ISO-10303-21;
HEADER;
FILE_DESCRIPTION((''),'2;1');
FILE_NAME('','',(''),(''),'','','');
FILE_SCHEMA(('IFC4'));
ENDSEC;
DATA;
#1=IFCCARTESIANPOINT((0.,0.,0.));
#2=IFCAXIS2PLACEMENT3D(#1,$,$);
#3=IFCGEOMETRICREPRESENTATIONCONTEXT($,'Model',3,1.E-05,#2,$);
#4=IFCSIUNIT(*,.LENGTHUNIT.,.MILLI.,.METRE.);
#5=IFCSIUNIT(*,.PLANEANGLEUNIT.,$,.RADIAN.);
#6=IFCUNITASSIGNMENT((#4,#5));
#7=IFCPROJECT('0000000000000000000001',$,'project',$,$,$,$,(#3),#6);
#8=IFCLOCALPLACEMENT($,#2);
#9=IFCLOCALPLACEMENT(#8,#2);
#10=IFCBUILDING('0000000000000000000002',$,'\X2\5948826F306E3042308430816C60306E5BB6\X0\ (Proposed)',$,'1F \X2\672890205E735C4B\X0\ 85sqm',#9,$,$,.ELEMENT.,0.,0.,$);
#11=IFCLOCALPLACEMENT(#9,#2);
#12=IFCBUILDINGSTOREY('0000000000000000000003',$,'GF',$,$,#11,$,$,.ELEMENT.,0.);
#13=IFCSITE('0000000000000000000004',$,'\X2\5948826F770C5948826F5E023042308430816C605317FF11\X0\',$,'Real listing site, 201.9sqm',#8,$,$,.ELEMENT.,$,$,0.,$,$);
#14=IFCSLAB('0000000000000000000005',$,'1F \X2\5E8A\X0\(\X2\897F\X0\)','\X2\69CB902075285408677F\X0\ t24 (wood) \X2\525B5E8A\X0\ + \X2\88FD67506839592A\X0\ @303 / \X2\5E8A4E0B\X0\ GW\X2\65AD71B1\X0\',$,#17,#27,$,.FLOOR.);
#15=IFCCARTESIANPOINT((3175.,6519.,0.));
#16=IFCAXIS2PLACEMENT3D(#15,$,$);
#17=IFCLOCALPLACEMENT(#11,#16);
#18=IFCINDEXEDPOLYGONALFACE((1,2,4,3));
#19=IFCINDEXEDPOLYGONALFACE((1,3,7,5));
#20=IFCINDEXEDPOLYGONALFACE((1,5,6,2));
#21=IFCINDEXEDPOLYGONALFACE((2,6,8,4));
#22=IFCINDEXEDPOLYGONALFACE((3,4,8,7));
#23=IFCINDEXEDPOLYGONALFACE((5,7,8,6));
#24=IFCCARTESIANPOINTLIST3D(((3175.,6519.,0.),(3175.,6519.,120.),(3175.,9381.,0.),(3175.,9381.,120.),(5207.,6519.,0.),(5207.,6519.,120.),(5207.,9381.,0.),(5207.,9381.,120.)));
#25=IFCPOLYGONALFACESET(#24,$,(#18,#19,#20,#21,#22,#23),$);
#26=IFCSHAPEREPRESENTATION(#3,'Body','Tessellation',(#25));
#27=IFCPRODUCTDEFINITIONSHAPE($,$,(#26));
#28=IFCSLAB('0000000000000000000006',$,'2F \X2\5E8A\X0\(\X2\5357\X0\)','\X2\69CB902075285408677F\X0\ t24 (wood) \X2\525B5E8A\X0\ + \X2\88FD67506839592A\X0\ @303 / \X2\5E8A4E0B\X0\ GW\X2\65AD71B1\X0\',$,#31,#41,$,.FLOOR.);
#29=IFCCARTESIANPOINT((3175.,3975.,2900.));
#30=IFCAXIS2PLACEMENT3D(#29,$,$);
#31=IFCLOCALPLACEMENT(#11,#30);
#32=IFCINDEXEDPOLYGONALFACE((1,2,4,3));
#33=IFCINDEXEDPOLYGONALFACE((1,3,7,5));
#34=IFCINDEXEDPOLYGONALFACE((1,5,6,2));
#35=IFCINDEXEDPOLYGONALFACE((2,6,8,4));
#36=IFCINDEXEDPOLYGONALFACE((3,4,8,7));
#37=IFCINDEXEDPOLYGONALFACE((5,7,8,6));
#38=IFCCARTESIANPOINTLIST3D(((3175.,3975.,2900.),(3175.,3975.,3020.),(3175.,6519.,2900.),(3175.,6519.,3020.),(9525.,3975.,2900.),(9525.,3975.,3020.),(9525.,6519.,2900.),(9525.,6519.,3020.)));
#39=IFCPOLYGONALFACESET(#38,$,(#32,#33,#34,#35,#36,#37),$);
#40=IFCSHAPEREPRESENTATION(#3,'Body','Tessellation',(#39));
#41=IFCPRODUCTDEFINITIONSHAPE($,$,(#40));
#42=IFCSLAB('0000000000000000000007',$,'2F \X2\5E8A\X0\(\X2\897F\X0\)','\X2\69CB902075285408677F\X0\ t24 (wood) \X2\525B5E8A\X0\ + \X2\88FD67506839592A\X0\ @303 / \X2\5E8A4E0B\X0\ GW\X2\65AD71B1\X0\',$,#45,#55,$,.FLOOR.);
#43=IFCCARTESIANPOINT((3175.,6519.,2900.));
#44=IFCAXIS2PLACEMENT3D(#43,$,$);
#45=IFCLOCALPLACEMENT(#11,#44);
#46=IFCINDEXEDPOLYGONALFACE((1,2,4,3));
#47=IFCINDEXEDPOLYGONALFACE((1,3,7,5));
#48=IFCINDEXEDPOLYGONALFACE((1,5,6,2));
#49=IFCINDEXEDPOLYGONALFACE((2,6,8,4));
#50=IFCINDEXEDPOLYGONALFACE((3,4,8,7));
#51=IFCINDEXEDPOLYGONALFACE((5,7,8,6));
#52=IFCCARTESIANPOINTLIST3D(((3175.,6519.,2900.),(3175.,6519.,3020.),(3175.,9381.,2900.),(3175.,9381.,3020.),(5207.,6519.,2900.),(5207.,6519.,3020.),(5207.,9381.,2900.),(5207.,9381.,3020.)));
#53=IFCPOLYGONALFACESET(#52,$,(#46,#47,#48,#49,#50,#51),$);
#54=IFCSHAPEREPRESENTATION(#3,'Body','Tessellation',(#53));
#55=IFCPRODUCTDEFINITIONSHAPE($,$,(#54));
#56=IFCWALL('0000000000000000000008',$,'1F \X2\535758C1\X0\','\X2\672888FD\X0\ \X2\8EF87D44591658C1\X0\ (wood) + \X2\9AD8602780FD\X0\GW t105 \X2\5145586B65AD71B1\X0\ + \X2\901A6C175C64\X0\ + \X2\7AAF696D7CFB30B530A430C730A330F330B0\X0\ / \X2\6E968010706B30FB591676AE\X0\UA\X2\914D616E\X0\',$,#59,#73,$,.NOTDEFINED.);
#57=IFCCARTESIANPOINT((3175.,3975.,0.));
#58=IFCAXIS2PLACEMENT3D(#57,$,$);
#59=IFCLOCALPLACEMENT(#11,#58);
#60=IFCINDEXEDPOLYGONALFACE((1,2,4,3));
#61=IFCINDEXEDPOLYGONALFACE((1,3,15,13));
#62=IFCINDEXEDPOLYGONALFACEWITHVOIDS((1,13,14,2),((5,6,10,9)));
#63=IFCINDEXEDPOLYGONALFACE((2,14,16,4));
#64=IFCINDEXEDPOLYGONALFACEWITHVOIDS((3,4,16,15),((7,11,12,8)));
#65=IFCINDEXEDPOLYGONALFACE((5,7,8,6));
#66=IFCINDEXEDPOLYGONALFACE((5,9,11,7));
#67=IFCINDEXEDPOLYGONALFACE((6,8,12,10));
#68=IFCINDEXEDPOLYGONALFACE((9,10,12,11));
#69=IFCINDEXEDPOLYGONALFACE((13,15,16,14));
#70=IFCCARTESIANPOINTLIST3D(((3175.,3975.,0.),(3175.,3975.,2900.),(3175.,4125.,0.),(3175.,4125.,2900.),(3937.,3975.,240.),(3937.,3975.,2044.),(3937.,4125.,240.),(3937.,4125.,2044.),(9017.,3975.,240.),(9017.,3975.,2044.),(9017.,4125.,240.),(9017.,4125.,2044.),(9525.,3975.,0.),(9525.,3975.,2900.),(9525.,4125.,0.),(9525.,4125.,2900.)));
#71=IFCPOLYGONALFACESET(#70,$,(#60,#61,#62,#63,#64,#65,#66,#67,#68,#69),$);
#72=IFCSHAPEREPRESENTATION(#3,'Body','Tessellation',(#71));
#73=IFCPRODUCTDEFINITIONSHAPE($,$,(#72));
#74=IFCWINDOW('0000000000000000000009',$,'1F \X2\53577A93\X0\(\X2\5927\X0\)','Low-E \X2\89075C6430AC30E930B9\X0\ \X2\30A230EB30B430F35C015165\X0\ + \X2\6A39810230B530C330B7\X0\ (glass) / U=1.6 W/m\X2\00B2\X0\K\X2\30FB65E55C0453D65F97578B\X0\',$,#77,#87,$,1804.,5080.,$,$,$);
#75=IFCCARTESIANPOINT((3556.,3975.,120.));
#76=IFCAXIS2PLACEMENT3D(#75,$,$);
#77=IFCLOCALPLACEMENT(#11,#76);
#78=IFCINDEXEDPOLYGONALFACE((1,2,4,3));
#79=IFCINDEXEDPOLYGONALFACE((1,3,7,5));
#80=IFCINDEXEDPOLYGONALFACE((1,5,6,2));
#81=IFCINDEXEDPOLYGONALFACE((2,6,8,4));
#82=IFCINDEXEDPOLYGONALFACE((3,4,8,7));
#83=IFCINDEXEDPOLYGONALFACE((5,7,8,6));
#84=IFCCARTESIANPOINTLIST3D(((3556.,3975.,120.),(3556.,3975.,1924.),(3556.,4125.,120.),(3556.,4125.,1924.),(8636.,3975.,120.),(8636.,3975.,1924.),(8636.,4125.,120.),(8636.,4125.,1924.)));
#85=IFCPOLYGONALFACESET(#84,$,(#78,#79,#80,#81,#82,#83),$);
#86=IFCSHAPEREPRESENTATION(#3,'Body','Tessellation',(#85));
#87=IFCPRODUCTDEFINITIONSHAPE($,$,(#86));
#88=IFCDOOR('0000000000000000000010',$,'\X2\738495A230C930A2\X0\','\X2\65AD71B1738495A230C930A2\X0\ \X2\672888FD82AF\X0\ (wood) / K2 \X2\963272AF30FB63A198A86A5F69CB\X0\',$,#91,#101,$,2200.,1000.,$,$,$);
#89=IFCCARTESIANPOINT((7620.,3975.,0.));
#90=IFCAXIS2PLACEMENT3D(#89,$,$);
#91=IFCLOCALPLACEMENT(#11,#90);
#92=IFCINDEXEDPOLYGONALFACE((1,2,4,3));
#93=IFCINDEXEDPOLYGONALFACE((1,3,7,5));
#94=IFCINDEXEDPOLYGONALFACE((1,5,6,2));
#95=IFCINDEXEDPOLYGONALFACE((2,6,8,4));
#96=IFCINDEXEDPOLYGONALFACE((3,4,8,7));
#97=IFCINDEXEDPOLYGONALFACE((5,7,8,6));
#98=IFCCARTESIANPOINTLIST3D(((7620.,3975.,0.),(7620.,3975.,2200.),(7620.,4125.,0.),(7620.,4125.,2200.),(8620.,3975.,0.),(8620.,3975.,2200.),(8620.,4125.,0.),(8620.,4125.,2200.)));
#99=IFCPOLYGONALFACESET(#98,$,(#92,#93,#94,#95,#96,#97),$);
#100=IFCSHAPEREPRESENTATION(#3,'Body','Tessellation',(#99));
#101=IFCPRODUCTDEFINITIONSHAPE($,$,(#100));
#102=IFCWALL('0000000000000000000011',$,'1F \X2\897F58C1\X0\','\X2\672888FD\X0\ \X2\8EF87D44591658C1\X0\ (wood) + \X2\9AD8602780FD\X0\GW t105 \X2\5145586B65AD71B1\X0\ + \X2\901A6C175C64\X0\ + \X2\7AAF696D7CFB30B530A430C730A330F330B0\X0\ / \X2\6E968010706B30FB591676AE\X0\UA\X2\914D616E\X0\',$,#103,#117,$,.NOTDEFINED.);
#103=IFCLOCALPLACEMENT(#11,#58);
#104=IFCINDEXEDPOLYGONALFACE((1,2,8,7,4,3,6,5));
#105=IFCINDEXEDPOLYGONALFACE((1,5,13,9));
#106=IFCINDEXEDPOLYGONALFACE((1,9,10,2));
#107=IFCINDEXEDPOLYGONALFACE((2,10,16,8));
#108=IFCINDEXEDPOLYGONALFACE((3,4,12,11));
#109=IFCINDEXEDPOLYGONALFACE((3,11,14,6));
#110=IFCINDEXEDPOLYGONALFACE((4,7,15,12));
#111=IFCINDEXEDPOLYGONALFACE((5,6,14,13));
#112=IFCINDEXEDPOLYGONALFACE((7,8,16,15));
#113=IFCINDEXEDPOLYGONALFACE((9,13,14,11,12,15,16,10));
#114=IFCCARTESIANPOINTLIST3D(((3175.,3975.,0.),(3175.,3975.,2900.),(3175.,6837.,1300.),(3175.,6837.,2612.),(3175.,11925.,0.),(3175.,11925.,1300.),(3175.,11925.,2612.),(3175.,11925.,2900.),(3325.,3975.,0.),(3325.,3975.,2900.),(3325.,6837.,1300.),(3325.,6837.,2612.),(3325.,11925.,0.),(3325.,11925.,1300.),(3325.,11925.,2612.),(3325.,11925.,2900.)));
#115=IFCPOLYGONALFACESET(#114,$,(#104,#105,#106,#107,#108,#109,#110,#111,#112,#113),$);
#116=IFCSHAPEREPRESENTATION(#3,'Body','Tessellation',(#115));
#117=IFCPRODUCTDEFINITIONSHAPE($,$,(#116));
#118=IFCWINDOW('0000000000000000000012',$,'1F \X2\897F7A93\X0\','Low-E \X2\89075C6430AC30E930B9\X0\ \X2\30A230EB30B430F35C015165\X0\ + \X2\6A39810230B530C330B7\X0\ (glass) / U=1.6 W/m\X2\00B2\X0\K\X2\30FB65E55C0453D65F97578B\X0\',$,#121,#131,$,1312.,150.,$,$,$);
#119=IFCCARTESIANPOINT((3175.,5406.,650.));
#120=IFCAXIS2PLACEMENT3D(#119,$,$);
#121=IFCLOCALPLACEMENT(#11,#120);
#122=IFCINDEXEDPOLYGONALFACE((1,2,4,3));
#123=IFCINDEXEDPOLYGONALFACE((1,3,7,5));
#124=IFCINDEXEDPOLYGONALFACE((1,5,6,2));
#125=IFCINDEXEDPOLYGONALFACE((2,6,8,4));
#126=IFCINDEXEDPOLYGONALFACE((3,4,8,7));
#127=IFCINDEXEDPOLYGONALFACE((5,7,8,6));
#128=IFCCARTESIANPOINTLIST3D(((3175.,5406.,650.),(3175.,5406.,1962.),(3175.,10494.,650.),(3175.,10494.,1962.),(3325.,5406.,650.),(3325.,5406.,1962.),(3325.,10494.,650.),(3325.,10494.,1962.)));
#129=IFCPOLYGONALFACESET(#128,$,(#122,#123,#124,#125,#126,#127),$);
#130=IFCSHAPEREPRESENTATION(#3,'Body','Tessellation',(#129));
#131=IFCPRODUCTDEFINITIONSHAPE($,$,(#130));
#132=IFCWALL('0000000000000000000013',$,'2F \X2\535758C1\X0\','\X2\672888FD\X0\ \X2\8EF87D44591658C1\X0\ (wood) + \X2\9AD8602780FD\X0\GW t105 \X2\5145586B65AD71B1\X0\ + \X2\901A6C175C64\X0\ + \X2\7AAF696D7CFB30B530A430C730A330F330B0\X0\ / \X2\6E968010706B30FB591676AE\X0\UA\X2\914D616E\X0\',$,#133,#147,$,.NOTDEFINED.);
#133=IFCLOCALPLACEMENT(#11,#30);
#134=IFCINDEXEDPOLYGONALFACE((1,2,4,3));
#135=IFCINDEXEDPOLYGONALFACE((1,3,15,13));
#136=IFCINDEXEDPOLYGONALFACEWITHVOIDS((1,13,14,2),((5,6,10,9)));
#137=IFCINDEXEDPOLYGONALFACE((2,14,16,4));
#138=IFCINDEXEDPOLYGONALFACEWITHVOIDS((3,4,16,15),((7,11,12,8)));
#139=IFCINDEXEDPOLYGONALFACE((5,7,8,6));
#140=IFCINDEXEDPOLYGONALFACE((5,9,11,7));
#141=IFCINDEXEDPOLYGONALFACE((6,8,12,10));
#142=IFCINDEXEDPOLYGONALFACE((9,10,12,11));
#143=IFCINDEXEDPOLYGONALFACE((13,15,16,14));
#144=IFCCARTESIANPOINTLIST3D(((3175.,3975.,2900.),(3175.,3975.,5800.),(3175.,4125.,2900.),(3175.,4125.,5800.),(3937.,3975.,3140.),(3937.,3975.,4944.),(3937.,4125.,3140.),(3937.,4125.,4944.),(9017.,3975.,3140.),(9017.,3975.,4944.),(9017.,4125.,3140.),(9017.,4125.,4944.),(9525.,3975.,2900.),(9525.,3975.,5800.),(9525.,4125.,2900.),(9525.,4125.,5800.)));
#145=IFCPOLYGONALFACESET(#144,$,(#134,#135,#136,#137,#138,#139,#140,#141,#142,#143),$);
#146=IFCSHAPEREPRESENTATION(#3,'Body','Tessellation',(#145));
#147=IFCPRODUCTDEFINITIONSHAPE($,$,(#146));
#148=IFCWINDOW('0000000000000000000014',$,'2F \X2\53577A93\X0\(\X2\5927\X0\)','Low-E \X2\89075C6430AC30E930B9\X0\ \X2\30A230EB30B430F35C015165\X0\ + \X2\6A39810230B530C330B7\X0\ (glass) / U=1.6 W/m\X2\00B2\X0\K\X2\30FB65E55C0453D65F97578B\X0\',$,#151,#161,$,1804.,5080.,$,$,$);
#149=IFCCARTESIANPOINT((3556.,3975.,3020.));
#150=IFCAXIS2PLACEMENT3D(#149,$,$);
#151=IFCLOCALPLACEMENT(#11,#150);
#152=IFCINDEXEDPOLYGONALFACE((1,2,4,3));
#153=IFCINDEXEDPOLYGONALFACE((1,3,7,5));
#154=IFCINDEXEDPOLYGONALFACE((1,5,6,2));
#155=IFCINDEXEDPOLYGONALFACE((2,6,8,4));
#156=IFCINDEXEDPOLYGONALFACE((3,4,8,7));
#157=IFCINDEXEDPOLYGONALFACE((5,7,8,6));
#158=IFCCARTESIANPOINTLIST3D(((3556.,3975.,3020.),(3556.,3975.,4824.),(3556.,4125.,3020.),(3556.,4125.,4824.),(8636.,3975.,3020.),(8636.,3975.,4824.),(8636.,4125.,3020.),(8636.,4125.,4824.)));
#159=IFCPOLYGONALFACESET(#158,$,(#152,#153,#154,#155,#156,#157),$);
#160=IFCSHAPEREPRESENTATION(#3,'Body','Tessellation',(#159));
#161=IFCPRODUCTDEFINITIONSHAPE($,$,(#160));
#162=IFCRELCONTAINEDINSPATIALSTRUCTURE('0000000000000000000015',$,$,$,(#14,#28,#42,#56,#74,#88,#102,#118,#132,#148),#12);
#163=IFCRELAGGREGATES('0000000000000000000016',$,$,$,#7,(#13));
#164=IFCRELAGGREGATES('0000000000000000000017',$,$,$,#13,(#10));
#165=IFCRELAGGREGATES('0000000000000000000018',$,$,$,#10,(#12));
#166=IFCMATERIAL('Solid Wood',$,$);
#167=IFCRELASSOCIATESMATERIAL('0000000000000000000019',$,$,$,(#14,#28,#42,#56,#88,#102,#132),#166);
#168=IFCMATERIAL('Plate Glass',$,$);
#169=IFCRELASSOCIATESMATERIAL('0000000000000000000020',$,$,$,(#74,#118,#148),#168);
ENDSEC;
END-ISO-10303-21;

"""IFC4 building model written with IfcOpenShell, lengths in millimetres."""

from ifc_helpers import new_model, si_unit, frame, frame_2d, origin, place, context, project, spatial, rectangle, extrude, material, element, fill, save


model = new_model("IFC4")

# Units and contexts
model_context = context("Model", 3, precision=1e-05, world=origin())
ifc_project = project(units=[si_unit("LENGTHUNIT", "METRE", prefix="MILLI"), si_unit("PLANEANGLEUNIT", "RADIAN")], contexts=[model_context])

# Site, building, storey
site_placement = place(None, origin())
site = spatial("IfcSite", under=ifc_project, at=site_placement, Name="奈良県奈良市あやめ池北１", ObjectType="Real listing site, 201.9sqm", CompositionType="ELEMENT", RefElevation=0.0)
building_placement = place(site_placement, origin())
building = spatial("IfcBuilding", under=site, at=building_placement, Name="奈良のあやめ池の家 (Proposed)", ObjectType="1F 木造平屋 85sqm", CompositionType="ELEMENT", ElevationOfRefHeight=0.0, ElevationOfTerrain=0.0)
storey_placement = place(building_placement, origin())
storey = spatial("IfcBuildingStorey", under=building, at=storey_placement, Name="GF", CompositionType="ELEMENT", Elevation=0.0)

# Slabs
ifc_material_1 = material(Name="Solid Wood")
slab_1_placement = place(storey_placement, frame((3175.0, 6519.0, 0.0)))
element("IfcSlab", 1, at=slab_1_placement, inside=storey, material=ifc_material_1, Name="1F 床(西)", Description="構造用合板 t24 (wood) 剛床 + 製材根太 @303 / 床下 GW断熱", PredefinedType="FLOOR", context=model_context, shape_type="SweptSolid", body=[
    extrude(rectangle(XDim=2032.0, YDim=2862.0, at=frame_2d((1016.0, 1431.0))), frame((3175.0, 6519.0, 0.0)), (0.0, 0.0, 1.0), 120.0),
])
slab_2_placement = place(storey_placement, frame((3175.0, 3975.0, 2900.0)))
element("IfcSlab", 2, at=slab_2_placement, inside=storey, material=ifc_material_1, Name="2F 床(南)", Description="構造用合板 t24 (wood) 剛床 + 製材根太 @303 / 床下 GW断熱", PredefinedType="FLOOR", context=model_context, shape_type="SweptSolid", body=[
    extrude(rectangle(XDim=6350.0, YDim=2544.0, at=frame_2d((3175.0, 1272.0))), frame((3175.0, 3975.0, 2900.0)), (0.0, 0.0, 1.0), 120.0),
])
slab_3_placement = place(storey_placement, frame((3175.0, 6519.0, 2900.0)))
element("IfcSlab", 3, at=slab_3_placement, inside=storey, material=ifc_material_1, Name="2F 床(西)", Description="構造用合板 t24 (wood) 剛床 + 製材根太 @303 / 床下 GW断熱", PredefinedType="FLOOR", context=model_context, shape_type="SweptSolid", body=[
    extrude(rectangle(XDim=2032.0, YDim=2862.0, at=frame_2d((1016.0, 1431.0))), frame((3175.0, 6519.0, 2900.0)), (0.0, 0.0, 1.0), 120.0),
])

# Wall, openings, window, door
wall_1_placement = place(storey_placement, frame((3175.0, 3975.0, 0.0)))
wall_1 = element("IfcWall", 4, at=wall_1_placement, inside=storey, material=ifc_material_1, Name="1F 南壁", Description="木製 軸組外壁 (wood) + 高性能GW t105 充填断熱 + 通気層 + 窯業系サイディング / 準耐火・外皮UA配慮", PredefinedType="NOTDEFINED", context=model_context, shape_type="SweptSolid", body=[
    extrude(rectangle(XDim=6350.0, YDim=150.0, at=frame_2d((3175.0, 75.0))), frame((3175.0, 3975.0, 0.0)), (0.0, 0.0, 1.0), 2900.0),
])
opening_1_placement = place(storey_placement, frame((3556.0, 3975.0, 120.0)))
opening_1 = element("IfcOpeningElement", 5, at=opening_1_placement, cuts=wall_1, PredefinedType="NOTDEFINED", context=model_context, shape_type="SweptSolid", body=[
    extrude(rectangle(XDim=5080.0, YDim=150.0, at=frame_2d((2540.0, 75.0))), frame((3556.0, 3975.0, 120.0)), (0.0, 0.0, 1.0), 1804.0),
])
opening_2_placement = place(storey_placement, frame((7620.0, 3975.0, 0.0)))
opening_2 = element("IfcOpeningElement", 6, at=opening_2_placement, cuts=wall_1, PredefinedType="NOTDEFINED", context=model_context, shape_type="SweptSolid", body=[
    extrude(rectangle(XDim=1000.0, YDim=150.0, at=frame_2d((500.0, 75.0))), frame((7620.0, 3975.0, 0.0)), (0.0, 0.0, 1.0), 2200.0),
])
ifc_material_2 = material(Name="Plate Glass")
window_1_placement = place(storey_placement, frame((3556.0, 3975.0, 120.0)))
window_1 = element("IfcWindow", 7, at=window_1_placement, inside=storey, material=ifc_material_2, Name="1F 南窓(大)", Description="Low-E 複層ガラス アルゴン封入 + 樹脂サッシ (glass) / U=1.6 W/m²K・日射取得型", OverallHeight=1804.0, OverallWidth=5080.0, context=model_context, shape_type="SweptSolid", body=[
    extrude(rectangle(XDim=5080.0, YDim=150.0, at=frame_2d((2540.0, 75.0))), frame((3556.0, 3975.0, 120.0)), (0.0, 0.0, 1.0), 1804.0),
])
fill(opening_1, window_1)
door_placement = place(storey_placement, frame((7620.0, 3975.0, 0.0)))
door = element("IfcDoor", 8, at=door_placement, inside=storey, material=ifc_material_1, Name="玄関ドア", Description="断熱玄関ドア 木製芯 (wood) / K2 防犯・採風機構", OverallHeight=2200.0, OverallWidth=1000.0, context=model_context, shape_type="SweptSolid", body=[
    extrude(rectangle(XDim=1000.0, YDim=150.0, at=frame_2d((500.0, 75.0))), frame((7620.0, 3975.0, 0.0)), (0.0, 0.0, 1.0), 2200.0),
])
fill(opening_2, door)

# Walls, openings, windows
wall_2_placement = place(storey_placement, frame((3175.0, 3975.0, 0.0)))
wall_2 = element("IfcWall", 9, at=wall_2_placement, inside=storey, material=ifc_material_1, Name="1F 西壁", Description="木製 軸組外壁 (wood) + 高性能GW t105 充填断熱 + 通気層 + 窯業系サイディング / 準耐火・外皮UA配慮", PredefinedType="NOTDEFINED", context=model_context, shape_type="SweptSolid", body=[
    extrude(rectangle(XDim=150.0, YDim=7950.0, at=frame_2d((75.0, 3975.0))), frame((3175.0, 3975.0, 0.0)), (0.0, 0.0, 1.0), 2900.0),
])
opening_3_placement = place(storey_placement, frame((3175.0, 5406.0, 650.0)))
opening_3 = element("IfcOpeningElement", 10, at=opening_3_placement, cuts=wall_2, PredefinedType="NOTDEFINED", context=model_context, shape_type="SweptSolid", body=[
    extrude(rectangle(XDim=150.0, YDim=5088.0, at=frame_2d((75.0, 2544.0))), frame((3175.0, 5406.0, 650.0)), (0.0, 0.0, 1.0), 1312.0),
])
window_2_placement = place(storey_placement, frame((3175.0, 5406.0, 650.0)))
window_2 = element("IfcWindow", 11, at=window_2_placement, inside=storey, material=ifc_material_2, Name="1F 西窓", Description="Low-E 複層ガラス アルゴン封入 + 樹脂サッシ (glass) / U=1.6 W/m²K・日射取得型", OverallHeight=1312.0, OverallWidth=150.0, context=model_context, shape_type="SweptSolid", body=[
    extrude(rectangle(XDim=150.0, YDim=5088.0, at=frame_2d((75.0, 2544.0))), frame((3175.0, 5406.0, 650.0)), (0.0, 0.0, 1.0), 1312.0),
])
fill(opening_3, window_2)
wall_3_placement = place(storey_placement, frame((3175.0, 3975.0, 2900.0)))
wall_3 = element("IfcWall", 12, at=wall_3_placement, inside=storey, material=ifc_material_1, Name="2F 南壁", Description="木製 軸組外壁 (wood) + 高性能GW t105 充填断熱 + 通気層 + 窯業系サイディング / 準耐火・外皮UA配慮", PredefinedType="NOTDEFINED", context=model_context, shape_type="SweptSolid", body=[
    extrude(rectangle(XDim=6350.0, YDim=150.0, at=frame_2d((3175.0, 75.0))), frame((3175.0, 3975.0, 2900.0)), (0.0, 0.0, 1.0), 2900.0),
])
opening_4_placement = place(storey_placement, frame((3556.0, 3975.0, 3020.0)))
opening_4 = element("IfcOpeningElement", 13, at=opening_4_placement, cuts=wall_3, PredefinedType="NOTDEFINED", context=model_context, shape_type="SweptSolid", body=[
    extrude(rectangle(XDim=5080.0, YDim=150.0, at=frame_2d((2540.0, 75.0))), frame((3556.0, 3975.0, 3020.0)), (0.0, 0.0, 1.0), 1804.0),
])
window_3_placement = place(storey_placement, frame((3556.0, 3975.0, 3020.0)))
window_3 = element("IfcWindow", 14, at=window_3_placement, inside=storey, material=ifc_material_2, Name="2F 南窓(大)", Description="Low-E 複層ガラス アルゴン封入 + 樹脂サッシ (glass) / U=1.6 W/m²K・日射取得型", OverallHeight=1804.0, OverallWidth=5080.0, context=model_context, shape_type="SweptSolid", body=[
    extrude(rectangle(XDim=5080.0, YDim=150.0, at=frame_2d((2540.0, 75.0))), frame((3556.0, 3975.0, 3020.0)), (0.0, 0.0, 1.0), 1804.0),
])
fill(opening_4, window_3)

save(model, "model.ifc")
